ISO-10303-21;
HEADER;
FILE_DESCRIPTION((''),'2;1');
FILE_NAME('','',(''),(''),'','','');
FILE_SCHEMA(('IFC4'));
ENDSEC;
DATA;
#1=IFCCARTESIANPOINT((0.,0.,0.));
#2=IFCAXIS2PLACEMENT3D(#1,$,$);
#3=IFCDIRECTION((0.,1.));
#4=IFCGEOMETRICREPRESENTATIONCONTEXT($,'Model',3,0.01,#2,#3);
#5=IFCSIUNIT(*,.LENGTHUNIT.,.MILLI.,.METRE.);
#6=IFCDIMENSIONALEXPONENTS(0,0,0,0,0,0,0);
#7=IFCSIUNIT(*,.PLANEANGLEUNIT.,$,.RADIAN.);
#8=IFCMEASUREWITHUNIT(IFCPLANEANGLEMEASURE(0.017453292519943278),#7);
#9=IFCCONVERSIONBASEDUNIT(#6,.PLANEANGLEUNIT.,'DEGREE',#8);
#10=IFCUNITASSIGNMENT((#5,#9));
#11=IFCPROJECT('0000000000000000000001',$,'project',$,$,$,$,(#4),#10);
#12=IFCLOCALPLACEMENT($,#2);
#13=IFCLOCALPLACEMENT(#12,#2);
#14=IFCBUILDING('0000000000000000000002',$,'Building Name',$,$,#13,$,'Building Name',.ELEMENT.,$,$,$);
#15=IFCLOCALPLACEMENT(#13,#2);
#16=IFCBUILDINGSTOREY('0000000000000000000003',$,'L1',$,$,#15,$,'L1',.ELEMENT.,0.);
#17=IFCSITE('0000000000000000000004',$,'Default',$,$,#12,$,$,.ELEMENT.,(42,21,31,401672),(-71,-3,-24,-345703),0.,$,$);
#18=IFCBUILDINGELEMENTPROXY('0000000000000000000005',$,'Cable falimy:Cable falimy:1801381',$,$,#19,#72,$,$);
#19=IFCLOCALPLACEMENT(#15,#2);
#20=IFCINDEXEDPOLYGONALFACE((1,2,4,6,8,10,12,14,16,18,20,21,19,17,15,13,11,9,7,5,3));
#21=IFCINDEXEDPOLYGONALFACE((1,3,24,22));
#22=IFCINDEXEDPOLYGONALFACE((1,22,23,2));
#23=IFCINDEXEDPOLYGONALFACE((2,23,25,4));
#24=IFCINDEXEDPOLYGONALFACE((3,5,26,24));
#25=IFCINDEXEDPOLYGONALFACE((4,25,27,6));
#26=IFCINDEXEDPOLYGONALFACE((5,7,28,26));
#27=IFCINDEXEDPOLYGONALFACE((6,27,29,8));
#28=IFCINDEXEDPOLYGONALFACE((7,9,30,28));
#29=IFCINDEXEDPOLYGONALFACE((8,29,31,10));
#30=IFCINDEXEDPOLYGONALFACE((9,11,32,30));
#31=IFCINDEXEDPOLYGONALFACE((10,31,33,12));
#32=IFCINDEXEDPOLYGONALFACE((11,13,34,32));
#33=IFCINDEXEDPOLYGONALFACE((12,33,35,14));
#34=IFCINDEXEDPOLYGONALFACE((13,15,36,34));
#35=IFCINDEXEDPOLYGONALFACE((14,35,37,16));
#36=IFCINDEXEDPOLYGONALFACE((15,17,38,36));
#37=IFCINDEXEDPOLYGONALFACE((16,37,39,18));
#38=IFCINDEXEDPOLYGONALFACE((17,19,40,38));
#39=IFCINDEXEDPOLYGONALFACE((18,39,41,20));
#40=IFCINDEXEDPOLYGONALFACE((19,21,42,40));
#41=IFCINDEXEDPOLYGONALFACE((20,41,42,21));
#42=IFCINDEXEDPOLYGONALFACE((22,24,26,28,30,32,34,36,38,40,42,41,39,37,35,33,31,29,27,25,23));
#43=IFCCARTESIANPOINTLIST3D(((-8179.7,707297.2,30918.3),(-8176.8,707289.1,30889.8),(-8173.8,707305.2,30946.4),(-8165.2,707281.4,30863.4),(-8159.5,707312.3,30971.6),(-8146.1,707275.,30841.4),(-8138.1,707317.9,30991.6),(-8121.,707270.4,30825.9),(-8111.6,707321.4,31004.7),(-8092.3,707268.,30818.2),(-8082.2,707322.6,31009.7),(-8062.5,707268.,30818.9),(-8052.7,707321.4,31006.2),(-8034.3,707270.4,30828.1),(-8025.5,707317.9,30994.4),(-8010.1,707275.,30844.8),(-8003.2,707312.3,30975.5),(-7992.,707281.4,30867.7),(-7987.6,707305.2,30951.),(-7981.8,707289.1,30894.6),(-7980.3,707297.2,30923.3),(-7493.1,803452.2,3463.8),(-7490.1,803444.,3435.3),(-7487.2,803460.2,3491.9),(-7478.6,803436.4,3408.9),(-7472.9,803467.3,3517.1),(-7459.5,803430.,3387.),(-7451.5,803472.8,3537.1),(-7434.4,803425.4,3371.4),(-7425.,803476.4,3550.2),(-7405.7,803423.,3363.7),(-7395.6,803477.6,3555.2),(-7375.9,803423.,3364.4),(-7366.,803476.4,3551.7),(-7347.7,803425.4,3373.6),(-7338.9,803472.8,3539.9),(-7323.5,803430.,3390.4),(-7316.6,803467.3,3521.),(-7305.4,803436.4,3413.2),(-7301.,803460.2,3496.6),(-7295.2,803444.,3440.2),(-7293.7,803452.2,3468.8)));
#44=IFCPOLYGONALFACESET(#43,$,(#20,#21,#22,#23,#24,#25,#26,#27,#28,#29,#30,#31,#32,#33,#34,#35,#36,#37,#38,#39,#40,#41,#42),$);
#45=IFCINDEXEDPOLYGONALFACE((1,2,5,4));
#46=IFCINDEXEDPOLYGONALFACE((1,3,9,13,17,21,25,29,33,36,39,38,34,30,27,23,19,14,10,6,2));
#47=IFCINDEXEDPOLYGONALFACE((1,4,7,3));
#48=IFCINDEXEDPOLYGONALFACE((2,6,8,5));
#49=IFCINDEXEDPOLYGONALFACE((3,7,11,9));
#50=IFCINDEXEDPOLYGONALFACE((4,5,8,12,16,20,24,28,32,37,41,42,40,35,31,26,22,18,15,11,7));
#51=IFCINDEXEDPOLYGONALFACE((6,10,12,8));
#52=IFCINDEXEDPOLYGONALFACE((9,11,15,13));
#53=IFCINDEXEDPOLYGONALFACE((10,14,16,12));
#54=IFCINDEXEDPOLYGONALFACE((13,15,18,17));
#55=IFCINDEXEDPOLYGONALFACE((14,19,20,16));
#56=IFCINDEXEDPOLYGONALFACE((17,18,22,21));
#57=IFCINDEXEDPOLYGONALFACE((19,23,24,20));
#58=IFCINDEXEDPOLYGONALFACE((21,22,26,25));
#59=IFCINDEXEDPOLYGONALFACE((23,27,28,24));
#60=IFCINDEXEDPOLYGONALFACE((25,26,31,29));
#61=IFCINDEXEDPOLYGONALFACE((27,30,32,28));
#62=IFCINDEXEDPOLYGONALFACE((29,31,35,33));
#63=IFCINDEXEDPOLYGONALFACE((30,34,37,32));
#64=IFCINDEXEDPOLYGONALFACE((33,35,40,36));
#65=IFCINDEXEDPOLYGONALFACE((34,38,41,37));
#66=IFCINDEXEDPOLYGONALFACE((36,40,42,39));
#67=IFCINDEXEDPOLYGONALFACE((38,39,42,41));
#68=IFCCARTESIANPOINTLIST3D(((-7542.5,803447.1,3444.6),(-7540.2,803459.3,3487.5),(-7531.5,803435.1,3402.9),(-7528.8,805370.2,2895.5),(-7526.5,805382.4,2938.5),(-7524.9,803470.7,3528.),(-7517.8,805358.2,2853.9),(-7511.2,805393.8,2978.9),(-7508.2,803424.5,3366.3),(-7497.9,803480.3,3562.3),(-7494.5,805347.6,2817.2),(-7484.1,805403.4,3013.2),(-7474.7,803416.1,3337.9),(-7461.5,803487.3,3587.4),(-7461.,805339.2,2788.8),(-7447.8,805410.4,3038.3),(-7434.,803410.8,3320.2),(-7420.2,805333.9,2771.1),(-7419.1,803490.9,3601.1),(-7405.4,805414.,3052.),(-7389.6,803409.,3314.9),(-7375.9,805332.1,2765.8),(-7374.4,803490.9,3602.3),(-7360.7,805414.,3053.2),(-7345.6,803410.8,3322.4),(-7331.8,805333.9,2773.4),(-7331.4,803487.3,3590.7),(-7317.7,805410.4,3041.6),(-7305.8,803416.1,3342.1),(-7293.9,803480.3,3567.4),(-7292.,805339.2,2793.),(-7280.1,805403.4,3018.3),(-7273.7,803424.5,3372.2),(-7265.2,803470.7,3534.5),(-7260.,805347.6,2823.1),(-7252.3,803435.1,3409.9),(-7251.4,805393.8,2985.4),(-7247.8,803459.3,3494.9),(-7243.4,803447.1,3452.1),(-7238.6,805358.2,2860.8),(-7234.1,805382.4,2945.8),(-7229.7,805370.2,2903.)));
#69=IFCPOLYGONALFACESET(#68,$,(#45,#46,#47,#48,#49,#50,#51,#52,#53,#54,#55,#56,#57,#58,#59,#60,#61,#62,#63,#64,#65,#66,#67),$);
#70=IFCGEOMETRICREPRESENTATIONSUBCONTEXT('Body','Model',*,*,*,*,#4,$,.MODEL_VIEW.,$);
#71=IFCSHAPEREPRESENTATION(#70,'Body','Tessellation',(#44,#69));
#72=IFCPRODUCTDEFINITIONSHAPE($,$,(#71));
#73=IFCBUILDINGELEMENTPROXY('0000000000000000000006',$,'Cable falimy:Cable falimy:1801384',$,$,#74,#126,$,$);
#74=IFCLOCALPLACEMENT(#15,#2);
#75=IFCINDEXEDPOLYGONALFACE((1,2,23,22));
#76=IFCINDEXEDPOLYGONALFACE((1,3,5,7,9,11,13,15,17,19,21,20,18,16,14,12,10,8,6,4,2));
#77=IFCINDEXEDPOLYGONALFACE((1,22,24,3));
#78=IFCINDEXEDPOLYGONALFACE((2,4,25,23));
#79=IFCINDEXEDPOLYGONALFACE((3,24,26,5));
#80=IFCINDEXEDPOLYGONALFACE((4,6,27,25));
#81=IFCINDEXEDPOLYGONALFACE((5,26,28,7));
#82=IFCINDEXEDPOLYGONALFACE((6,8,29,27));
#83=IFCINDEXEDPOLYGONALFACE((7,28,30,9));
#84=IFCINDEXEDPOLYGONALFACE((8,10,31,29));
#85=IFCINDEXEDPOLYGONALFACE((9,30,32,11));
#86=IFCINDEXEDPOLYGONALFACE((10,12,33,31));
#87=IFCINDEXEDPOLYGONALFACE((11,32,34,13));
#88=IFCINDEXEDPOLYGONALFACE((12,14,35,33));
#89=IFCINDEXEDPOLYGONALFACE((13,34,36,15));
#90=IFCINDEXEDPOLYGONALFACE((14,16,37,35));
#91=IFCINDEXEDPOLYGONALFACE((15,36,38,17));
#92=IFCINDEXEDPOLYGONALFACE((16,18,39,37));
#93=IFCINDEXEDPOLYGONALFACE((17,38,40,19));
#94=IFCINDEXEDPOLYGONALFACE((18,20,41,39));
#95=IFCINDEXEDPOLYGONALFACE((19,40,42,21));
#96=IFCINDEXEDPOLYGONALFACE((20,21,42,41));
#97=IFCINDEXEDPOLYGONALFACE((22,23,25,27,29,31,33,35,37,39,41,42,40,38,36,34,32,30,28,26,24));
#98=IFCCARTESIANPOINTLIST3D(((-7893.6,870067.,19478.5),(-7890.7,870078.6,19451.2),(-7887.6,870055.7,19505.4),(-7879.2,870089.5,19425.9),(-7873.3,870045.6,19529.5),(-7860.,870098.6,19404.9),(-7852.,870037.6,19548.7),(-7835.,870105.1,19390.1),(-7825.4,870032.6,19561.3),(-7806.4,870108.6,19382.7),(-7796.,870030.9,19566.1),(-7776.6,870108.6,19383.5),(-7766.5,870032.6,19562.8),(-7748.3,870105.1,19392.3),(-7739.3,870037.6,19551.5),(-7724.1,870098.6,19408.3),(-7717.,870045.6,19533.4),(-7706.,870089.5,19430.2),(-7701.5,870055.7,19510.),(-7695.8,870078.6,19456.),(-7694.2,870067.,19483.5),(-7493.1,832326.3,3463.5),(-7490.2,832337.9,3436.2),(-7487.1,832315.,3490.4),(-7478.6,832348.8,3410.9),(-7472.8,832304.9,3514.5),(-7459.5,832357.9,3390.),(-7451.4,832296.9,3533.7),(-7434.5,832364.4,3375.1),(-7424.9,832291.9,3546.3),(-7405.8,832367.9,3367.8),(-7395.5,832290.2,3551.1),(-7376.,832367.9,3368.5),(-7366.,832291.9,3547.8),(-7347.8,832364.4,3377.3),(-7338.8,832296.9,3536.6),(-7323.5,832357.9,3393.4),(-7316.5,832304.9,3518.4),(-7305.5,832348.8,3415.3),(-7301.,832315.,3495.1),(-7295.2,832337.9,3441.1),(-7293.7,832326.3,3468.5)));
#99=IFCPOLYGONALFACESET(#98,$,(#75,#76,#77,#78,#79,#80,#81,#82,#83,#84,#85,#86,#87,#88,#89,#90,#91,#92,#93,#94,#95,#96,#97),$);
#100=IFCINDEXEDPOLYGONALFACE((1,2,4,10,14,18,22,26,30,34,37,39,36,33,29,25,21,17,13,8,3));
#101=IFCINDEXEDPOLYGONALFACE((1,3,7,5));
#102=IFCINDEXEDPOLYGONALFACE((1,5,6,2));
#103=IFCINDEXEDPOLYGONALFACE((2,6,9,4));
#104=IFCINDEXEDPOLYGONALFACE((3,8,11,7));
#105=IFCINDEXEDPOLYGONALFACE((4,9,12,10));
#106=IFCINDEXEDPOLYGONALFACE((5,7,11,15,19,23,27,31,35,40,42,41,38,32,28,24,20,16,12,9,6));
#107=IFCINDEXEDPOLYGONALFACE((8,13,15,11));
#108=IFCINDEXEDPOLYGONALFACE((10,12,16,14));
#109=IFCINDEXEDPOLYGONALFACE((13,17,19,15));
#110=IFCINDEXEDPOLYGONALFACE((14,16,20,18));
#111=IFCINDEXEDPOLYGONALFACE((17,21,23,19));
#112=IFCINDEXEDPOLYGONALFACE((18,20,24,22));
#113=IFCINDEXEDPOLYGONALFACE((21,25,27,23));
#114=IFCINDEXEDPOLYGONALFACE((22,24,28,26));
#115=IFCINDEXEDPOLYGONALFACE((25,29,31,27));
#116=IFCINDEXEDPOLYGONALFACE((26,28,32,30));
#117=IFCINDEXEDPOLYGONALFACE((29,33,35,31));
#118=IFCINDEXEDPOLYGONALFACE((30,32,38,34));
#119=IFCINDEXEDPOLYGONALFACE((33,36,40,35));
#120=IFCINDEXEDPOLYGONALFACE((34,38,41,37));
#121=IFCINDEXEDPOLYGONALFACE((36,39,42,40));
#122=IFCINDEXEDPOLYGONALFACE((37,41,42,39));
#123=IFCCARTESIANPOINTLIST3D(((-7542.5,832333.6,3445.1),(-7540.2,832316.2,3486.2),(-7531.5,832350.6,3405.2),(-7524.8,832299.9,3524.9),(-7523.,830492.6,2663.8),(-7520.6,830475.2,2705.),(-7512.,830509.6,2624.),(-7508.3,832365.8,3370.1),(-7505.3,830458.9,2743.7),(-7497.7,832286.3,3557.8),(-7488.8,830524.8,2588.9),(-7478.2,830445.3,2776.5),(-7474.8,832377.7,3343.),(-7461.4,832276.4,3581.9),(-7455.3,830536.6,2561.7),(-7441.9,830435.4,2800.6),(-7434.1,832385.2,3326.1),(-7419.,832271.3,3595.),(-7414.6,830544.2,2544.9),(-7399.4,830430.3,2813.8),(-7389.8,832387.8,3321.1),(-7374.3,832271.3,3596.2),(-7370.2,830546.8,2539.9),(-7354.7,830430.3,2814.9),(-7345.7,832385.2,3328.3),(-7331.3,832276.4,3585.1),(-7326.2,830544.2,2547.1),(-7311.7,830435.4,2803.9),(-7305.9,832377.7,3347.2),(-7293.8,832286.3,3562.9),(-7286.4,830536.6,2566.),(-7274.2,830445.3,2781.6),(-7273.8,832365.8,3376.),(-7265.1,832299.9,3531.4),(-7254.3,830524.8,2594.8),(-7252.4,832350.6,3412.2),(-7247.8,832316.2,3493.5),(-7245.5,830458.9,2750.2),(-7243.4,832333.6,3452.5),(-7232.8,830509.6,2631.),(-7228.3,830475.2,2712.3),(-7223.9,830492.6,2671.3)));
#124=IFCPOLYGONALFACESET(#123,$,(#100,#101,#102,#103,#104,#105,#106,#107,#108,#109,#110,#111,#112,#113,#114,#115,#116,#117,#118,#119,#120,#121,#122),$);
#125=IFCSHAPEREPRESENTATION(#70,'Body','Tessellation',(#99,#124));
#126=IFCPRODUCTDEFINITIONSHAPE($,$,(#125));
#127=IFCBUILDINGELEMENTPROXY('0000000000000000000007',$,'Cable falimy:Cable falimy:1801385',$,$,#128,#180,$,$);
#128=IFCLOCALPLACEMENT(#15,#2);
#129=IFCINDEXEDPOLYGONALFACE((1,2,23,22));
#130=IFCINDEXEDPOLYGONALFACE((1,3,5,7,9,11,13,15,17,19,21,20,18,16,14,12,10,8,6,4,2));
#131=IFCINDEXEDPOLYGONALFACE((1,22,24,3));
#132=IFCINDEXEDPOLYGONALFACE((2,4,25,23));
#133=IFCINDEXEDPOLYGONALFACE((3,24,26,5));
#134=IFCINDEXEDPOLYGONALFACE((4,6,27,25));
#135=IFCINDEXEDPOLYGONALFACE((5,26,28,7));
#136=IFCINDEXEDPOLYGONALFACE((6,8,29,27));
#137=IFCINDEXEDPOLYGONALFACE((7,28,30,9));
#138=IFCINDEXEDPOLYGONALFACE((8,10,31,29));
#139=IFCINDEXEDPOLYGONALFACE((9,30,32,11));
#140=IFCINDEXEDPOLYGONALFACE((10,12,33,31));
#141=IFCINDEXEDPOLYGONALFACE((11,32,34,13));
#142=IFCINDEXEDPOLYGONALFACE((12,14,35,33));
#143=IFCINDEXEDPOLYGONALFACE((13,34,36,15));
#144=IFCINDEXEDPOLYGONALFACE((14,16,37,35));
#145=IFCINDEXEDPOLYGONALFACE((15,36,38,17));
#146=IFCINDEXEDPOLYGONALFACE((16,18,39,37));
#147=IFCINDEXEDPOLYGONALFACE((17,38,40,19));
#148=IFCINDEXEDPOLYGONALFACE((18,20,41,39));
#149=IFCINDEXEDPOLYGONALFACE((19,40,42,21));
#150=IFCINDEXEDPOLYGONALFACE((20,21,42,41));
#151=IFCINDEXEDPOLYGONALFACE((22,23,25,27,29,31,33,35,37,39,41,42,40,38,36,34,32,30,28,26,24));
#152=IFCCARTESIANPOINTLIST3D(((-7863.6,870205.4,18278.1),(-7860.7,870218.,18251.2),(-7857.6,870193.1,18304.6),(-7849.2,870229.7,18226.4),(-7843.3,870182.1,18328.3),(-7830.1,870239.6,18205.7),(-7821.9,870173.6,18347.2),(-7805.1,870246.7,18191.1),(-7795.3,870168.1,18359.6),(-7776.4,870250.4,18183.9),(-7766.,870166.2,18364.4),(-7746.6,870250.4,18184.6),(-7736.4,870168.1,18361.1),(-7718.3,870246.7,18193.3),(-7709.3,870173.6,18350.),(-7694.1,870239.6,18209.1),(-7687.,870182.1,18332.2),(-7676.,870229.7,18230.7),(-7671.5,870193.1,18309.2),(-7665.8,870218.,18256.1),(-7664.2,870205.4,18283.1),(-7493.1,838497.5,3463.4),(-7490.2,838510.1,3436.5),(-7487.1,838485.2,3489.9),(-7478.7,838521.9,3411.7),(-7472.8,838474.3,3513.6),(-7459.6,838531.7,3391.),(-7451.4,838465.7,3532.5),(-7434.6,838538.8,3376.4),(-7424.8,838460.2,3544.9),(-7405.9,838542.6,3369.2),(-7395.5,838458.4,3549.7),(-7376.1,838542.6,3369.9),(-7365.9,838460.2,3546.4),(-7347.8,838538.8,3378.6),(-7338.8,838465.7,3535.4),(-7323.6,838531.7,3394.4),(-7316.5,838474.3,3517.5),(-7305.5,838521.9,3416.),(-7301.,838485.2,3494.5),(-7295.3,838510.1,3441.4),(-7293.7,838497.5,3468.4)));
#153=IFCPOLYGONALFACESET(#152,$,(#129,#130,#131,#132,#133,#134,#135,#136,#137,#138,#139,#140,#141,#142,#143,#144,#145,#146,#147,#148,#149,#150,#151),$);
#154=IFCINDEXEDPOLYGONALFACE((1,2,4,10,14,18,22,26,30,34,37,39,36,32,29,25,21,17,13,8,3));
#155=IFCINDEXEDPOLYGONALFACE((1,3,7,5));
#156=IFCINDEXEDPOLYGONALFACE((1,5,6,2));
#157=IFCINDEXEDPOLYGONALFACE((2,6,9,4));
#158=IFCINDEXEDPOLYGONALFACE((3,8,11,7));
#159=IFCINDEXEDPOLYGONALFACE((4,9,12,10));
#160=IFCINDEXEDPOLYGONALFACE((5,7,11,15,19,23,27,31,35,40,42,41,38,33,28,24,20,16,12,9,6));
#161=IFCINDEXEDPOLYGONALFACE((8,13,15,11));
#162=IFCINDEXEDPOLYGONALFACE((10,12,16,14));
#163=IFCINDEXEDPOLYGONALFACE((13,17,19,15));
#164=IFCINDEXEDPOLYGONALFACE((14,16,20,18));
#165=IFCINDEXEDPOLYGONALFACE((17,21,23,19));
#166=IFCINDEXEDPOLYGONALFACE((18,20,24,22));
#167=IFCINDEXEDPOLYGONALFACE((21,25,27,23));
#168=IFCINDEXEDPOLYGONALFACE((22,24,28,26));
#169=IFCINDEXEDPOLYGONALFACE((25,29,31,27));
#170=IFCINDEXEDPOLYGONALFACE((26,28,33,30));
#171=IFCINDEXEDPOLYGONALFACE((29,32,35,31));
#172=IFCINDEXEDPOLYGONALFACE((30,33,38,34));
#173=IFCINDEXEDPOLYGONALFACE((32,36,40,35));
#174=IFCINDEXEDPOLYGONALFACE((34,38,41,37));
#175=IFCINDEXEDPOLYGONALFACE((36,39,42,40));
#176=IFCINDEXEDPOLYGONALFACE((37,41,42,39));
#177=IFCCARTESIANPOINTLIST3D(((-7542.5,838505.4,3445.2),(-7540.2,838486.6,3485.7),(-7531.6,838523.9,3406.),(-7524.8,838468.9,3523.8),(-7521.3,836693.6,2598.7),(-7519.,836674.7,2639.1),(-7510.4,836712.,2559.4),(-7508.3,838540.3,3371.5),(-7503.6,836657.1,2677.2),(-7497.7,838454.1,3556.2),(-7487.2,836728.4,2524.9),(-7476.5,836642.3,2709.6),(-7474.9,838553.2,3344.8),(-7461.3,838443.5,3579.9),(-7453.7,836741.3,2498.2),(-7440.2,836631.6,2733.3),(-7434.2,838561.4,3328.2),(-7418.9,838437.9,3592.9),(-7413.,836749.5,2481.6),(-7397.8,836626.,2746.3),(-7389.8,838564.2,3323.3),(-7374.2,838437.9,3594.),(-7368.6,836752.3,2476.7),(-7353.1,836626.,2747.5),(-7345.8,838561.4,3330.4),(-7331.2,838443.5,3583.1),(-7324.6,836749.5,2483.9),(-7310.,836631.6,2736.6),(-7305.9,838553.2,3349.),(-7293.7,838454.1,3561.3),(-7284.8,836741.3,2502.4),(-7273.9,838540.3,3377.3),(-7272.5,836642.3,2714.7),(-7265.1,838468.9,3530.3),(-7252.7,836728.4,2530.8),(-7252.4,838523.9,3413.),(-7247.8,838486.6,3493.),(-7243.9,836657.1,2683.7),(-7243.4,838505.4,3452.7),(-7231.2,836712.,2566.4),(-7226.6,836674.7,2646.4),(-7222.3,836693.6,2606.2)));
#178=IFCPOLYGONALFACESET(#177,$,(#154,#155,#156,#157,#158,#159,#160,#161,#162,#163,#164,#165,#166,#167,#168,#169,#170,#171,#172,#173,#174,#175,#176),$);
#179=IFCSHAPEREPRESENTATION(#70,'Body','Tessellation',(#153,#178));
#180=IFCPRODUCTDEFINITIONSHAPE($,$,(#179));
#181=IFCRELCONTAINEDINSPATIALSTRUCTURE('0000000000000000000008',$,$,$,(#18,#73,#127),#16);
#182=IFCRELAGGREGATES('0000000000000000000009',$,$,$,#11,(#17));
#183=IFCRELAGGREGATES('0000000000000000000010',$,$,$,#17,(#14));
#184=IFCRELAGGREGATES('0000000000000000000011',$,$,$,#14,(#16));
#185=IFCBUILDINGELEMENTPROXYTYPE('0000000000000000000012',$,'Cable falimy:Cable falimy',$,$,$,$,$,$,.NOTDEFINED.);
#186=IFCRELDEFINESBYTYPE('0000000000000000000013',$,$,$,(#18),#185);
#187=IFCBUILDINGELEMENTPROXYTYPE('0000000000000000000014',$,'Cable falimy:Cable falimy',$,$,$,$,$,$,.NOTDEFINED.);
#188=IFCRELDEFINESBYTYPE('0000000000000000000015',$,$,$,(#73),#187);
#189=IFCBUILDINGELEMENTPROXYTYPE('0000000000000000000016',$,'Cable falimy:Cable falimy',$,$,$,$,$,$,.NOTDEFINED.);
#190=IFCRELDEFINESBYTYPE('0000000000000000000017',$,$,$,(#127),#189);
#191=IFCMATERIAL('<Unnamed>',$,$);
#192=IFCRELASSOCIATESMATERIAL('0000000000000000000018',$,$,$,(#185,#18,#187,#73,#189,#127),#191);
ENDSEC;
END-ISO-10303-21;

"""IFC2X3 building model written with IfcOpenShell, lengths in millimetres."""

from ifc_helpers import new_model, entity, si_unit, converted_unit, direction, frame, frame_2d, origin, place, context, subcontext, project, spatial, circle, extrude, source, transform, mapped, material, type_object, type_shapes, element, save


model = new_model("IFC2X3")

# Units and contexts
model_context = context("Model", 3, precision=0.01, world=origin(), true_north=direction((0.0, 1.0)))
body_context = subcontext(model_context, "Body", "Model", "MODEL_VIEW")
ifc_project = project(units=[si_unit("LENGTHUNIT", "METRE", prefix="MILLI"), converted_unit("PLANEANGLEUNIT", "DEGREE", entity("IfcPlaneAngleMeasure", 0.017453292519943278), si_unit("PLANEANGLEUNIT", "RADIAN"), dimensions=[0, 0, 0, 0, 0, 0, 0])], contexts=[model_context])

# Site, building, storey
site_placement = place(None, origin())
site = spatial("IfcSite", under=ifc_project, at=site_placement, Name="Default", CompositionType="ELEMENT", RefLatitude=(42, 21, 31, 401672), RefLongitude=(-71, -3, -24, -345703), RefElevation=0.0)
building_placement = place(site_placement, origin())
building = spatial("IfcBuilding", under=site, at=building_placement, Name="Building Name", LongName="Building Name", CompositionType="ELEMENT")
storey_placement = place(building_placement, origin())
storey = spatial("IfcBuildingStorey", under=building, at=storey_placement, Name="L1", LongName="L1", CompositionType="ELEMENT", Elevation=0.0)

# Shared definitions
ifc_material = material(Name="<Unnamed>")

# Building element proxies
building_element_proxy_type_1 = type_object("IfcBuildingElementProxyType", Name="Cable falimy:Cable falimy", PredefinedType="NOTDEFINED", material=ifc_material)
shared_shape_1 = source(origin(), body_context, "Body", "SweptSolid", [
    extrude(circle(Radius=100.0, at=frame_2d((0.0, 0.0), x_axis=(1.0, 0.0))), frame((0.0, 0.0, 0.0), z_axis=(0.96155, 0.0, 0.274631), x_axis=(-0.274631, 0.0, 0.96155)), (0.0, 0.0, 1.0), 100000.0),
    extrude(circle(Radius=150.0, at=frame_2d((0.0, 0.0), x_axis=(1.0, 0.0))), frame((-1923.1, 0.0, -549.3), z_axis=(0.96155, 0.0, 0.274631), x_axis=(0.274631, 0.0, -0.96155)), (0.0, 0.0, 1.0), 2000.0),
])
type_shapes(building_element_proxy_type_1, [shared_shape_1])
proxy_1_placement = place(storey_placement, frame((-7393.2, 803450.1, 3459.1), z_axis=(-0.025001, 0.0, 0.999687), x_axis=(0.0, -1.0, 0.0)))
element("IfcBuildingElementProxy", 1, at=proxy_1_placement, inside=storey, type_object=building_element_proxy_type_1, material=ifc_material, Name="Cable falimy:Cable falimy:1801381", context=body_context, shape_type="MappedRepresentation", body=[
    mapped(shared_shape_1, transform((0.0, 0.0, 0.0), scale=1.0)),
])
building_element_proxy_type_2 = type_object("IfcBuildingElementProxyType", Name="Cable falimy:Cable falimy", PredefinedType="NOTDEFINED", material=ifc_material)
shared_shape_2 = source(origin(), body_context, "Body", "SweptSolid", [
    extrude(circle(Radius=100.0, at=frame_2d((0.0, 0.0), x_axis=(1.0, 0.0))), frame((0.0, 0.0, 0.0), z_axis=(0.920505, 0.0, 0.390731), x_axis=(-0.390731, 0.0, 0.920505)), (0.0, 0.0, 1.0), 41000.0),
    extrude(circle(Radius=150.0, at=frame_2d((0.0, 0.0), x_axis=(1.0, 0.0))), frame((-1841.0, 0.0, -781.5), z_axis=(0.920505, 0.0, 0.390731), x_axis=(0.390731, 0.0, -0.920505)), (0.0, 0.0, 1.0), 2000.0),
])
type_shapes(building_element_proxy_type_2, [shared_shape_2])
proxy_2_placement = place(storey_placement, frame((-7393.2, 832329.2, 3459.1), z_axis=(-0.025001, 0.0, 0.999687), x_axis=(0.0, 1.0, 0.0)))
element("IfcBuildingElementProxy", 2, at=proxy_2_placement, inside=storey, type_object=building_element_proxy_type_2, material=ifc_material, Name="Cable falimy:Cable falimy:1801384", context=body_context, shape_type="MappedRepresentation", body=[
    mapped(shared_shape_2, transform((0.0, 0.0, 0.0), scale=1.0)),
])
building_element_proxy_type_3 = type_object("IfcBuildingElementProxyType", Name="Cable falimy:Cable falimy", PredefinedType="NOTDEFINED", material=ifc_material)
shared_shape_3 = source(origin(), body_context, "Body", "SweptSolid", [
    extrude(circle(Radius=100.0, at=frame_2d((0.0, 0.0), x_axis=(1.0, 0.0))), frame((0.0, 0.0, 0.0), z_axis=(0.905939, 0.0, 0.423409), x_axis=(-0.423409, 0.0, 0.905939)), (0.0, 0.0, 1.0), 35000.0),
    extrude(circle(Radius=150.0, at=frame_2d((0.0, 0.0), x_axis=(1.0, 0.0))), frame((-1811.9, 0.0, -846.8), z_axis=(0.905939, 0.0, 0.423409), x_axis=(0.423409, 0.0, -0.905939)), (0.0, 0.0, 1.0), 2000.0),
])
type_shapes(building_element_proxy_type_3, [shared_shape_3])
proxy_3_placement = place(storey_placement, frame((-7393.2, 838500.7, 3459.1), z_axis=(-0.025001, 0.0, 0.999687), x_axis=(0.0, 1.0, 0.0)))
element("IfcBuildingElementProxy", 3, at=proxy_3_placement, inside=storey, type_object=building_element_proxy_type_3, material=ifc_material, Name="Cable falimy:Cable falimy:1801385", context=body_context, shape_type="MappedRepresentation", body=[
    mapped(shared_shape_3, transform((0.0, 0.0, 0.0), scale=1.0)),
])

save(model, "model.ifc")
